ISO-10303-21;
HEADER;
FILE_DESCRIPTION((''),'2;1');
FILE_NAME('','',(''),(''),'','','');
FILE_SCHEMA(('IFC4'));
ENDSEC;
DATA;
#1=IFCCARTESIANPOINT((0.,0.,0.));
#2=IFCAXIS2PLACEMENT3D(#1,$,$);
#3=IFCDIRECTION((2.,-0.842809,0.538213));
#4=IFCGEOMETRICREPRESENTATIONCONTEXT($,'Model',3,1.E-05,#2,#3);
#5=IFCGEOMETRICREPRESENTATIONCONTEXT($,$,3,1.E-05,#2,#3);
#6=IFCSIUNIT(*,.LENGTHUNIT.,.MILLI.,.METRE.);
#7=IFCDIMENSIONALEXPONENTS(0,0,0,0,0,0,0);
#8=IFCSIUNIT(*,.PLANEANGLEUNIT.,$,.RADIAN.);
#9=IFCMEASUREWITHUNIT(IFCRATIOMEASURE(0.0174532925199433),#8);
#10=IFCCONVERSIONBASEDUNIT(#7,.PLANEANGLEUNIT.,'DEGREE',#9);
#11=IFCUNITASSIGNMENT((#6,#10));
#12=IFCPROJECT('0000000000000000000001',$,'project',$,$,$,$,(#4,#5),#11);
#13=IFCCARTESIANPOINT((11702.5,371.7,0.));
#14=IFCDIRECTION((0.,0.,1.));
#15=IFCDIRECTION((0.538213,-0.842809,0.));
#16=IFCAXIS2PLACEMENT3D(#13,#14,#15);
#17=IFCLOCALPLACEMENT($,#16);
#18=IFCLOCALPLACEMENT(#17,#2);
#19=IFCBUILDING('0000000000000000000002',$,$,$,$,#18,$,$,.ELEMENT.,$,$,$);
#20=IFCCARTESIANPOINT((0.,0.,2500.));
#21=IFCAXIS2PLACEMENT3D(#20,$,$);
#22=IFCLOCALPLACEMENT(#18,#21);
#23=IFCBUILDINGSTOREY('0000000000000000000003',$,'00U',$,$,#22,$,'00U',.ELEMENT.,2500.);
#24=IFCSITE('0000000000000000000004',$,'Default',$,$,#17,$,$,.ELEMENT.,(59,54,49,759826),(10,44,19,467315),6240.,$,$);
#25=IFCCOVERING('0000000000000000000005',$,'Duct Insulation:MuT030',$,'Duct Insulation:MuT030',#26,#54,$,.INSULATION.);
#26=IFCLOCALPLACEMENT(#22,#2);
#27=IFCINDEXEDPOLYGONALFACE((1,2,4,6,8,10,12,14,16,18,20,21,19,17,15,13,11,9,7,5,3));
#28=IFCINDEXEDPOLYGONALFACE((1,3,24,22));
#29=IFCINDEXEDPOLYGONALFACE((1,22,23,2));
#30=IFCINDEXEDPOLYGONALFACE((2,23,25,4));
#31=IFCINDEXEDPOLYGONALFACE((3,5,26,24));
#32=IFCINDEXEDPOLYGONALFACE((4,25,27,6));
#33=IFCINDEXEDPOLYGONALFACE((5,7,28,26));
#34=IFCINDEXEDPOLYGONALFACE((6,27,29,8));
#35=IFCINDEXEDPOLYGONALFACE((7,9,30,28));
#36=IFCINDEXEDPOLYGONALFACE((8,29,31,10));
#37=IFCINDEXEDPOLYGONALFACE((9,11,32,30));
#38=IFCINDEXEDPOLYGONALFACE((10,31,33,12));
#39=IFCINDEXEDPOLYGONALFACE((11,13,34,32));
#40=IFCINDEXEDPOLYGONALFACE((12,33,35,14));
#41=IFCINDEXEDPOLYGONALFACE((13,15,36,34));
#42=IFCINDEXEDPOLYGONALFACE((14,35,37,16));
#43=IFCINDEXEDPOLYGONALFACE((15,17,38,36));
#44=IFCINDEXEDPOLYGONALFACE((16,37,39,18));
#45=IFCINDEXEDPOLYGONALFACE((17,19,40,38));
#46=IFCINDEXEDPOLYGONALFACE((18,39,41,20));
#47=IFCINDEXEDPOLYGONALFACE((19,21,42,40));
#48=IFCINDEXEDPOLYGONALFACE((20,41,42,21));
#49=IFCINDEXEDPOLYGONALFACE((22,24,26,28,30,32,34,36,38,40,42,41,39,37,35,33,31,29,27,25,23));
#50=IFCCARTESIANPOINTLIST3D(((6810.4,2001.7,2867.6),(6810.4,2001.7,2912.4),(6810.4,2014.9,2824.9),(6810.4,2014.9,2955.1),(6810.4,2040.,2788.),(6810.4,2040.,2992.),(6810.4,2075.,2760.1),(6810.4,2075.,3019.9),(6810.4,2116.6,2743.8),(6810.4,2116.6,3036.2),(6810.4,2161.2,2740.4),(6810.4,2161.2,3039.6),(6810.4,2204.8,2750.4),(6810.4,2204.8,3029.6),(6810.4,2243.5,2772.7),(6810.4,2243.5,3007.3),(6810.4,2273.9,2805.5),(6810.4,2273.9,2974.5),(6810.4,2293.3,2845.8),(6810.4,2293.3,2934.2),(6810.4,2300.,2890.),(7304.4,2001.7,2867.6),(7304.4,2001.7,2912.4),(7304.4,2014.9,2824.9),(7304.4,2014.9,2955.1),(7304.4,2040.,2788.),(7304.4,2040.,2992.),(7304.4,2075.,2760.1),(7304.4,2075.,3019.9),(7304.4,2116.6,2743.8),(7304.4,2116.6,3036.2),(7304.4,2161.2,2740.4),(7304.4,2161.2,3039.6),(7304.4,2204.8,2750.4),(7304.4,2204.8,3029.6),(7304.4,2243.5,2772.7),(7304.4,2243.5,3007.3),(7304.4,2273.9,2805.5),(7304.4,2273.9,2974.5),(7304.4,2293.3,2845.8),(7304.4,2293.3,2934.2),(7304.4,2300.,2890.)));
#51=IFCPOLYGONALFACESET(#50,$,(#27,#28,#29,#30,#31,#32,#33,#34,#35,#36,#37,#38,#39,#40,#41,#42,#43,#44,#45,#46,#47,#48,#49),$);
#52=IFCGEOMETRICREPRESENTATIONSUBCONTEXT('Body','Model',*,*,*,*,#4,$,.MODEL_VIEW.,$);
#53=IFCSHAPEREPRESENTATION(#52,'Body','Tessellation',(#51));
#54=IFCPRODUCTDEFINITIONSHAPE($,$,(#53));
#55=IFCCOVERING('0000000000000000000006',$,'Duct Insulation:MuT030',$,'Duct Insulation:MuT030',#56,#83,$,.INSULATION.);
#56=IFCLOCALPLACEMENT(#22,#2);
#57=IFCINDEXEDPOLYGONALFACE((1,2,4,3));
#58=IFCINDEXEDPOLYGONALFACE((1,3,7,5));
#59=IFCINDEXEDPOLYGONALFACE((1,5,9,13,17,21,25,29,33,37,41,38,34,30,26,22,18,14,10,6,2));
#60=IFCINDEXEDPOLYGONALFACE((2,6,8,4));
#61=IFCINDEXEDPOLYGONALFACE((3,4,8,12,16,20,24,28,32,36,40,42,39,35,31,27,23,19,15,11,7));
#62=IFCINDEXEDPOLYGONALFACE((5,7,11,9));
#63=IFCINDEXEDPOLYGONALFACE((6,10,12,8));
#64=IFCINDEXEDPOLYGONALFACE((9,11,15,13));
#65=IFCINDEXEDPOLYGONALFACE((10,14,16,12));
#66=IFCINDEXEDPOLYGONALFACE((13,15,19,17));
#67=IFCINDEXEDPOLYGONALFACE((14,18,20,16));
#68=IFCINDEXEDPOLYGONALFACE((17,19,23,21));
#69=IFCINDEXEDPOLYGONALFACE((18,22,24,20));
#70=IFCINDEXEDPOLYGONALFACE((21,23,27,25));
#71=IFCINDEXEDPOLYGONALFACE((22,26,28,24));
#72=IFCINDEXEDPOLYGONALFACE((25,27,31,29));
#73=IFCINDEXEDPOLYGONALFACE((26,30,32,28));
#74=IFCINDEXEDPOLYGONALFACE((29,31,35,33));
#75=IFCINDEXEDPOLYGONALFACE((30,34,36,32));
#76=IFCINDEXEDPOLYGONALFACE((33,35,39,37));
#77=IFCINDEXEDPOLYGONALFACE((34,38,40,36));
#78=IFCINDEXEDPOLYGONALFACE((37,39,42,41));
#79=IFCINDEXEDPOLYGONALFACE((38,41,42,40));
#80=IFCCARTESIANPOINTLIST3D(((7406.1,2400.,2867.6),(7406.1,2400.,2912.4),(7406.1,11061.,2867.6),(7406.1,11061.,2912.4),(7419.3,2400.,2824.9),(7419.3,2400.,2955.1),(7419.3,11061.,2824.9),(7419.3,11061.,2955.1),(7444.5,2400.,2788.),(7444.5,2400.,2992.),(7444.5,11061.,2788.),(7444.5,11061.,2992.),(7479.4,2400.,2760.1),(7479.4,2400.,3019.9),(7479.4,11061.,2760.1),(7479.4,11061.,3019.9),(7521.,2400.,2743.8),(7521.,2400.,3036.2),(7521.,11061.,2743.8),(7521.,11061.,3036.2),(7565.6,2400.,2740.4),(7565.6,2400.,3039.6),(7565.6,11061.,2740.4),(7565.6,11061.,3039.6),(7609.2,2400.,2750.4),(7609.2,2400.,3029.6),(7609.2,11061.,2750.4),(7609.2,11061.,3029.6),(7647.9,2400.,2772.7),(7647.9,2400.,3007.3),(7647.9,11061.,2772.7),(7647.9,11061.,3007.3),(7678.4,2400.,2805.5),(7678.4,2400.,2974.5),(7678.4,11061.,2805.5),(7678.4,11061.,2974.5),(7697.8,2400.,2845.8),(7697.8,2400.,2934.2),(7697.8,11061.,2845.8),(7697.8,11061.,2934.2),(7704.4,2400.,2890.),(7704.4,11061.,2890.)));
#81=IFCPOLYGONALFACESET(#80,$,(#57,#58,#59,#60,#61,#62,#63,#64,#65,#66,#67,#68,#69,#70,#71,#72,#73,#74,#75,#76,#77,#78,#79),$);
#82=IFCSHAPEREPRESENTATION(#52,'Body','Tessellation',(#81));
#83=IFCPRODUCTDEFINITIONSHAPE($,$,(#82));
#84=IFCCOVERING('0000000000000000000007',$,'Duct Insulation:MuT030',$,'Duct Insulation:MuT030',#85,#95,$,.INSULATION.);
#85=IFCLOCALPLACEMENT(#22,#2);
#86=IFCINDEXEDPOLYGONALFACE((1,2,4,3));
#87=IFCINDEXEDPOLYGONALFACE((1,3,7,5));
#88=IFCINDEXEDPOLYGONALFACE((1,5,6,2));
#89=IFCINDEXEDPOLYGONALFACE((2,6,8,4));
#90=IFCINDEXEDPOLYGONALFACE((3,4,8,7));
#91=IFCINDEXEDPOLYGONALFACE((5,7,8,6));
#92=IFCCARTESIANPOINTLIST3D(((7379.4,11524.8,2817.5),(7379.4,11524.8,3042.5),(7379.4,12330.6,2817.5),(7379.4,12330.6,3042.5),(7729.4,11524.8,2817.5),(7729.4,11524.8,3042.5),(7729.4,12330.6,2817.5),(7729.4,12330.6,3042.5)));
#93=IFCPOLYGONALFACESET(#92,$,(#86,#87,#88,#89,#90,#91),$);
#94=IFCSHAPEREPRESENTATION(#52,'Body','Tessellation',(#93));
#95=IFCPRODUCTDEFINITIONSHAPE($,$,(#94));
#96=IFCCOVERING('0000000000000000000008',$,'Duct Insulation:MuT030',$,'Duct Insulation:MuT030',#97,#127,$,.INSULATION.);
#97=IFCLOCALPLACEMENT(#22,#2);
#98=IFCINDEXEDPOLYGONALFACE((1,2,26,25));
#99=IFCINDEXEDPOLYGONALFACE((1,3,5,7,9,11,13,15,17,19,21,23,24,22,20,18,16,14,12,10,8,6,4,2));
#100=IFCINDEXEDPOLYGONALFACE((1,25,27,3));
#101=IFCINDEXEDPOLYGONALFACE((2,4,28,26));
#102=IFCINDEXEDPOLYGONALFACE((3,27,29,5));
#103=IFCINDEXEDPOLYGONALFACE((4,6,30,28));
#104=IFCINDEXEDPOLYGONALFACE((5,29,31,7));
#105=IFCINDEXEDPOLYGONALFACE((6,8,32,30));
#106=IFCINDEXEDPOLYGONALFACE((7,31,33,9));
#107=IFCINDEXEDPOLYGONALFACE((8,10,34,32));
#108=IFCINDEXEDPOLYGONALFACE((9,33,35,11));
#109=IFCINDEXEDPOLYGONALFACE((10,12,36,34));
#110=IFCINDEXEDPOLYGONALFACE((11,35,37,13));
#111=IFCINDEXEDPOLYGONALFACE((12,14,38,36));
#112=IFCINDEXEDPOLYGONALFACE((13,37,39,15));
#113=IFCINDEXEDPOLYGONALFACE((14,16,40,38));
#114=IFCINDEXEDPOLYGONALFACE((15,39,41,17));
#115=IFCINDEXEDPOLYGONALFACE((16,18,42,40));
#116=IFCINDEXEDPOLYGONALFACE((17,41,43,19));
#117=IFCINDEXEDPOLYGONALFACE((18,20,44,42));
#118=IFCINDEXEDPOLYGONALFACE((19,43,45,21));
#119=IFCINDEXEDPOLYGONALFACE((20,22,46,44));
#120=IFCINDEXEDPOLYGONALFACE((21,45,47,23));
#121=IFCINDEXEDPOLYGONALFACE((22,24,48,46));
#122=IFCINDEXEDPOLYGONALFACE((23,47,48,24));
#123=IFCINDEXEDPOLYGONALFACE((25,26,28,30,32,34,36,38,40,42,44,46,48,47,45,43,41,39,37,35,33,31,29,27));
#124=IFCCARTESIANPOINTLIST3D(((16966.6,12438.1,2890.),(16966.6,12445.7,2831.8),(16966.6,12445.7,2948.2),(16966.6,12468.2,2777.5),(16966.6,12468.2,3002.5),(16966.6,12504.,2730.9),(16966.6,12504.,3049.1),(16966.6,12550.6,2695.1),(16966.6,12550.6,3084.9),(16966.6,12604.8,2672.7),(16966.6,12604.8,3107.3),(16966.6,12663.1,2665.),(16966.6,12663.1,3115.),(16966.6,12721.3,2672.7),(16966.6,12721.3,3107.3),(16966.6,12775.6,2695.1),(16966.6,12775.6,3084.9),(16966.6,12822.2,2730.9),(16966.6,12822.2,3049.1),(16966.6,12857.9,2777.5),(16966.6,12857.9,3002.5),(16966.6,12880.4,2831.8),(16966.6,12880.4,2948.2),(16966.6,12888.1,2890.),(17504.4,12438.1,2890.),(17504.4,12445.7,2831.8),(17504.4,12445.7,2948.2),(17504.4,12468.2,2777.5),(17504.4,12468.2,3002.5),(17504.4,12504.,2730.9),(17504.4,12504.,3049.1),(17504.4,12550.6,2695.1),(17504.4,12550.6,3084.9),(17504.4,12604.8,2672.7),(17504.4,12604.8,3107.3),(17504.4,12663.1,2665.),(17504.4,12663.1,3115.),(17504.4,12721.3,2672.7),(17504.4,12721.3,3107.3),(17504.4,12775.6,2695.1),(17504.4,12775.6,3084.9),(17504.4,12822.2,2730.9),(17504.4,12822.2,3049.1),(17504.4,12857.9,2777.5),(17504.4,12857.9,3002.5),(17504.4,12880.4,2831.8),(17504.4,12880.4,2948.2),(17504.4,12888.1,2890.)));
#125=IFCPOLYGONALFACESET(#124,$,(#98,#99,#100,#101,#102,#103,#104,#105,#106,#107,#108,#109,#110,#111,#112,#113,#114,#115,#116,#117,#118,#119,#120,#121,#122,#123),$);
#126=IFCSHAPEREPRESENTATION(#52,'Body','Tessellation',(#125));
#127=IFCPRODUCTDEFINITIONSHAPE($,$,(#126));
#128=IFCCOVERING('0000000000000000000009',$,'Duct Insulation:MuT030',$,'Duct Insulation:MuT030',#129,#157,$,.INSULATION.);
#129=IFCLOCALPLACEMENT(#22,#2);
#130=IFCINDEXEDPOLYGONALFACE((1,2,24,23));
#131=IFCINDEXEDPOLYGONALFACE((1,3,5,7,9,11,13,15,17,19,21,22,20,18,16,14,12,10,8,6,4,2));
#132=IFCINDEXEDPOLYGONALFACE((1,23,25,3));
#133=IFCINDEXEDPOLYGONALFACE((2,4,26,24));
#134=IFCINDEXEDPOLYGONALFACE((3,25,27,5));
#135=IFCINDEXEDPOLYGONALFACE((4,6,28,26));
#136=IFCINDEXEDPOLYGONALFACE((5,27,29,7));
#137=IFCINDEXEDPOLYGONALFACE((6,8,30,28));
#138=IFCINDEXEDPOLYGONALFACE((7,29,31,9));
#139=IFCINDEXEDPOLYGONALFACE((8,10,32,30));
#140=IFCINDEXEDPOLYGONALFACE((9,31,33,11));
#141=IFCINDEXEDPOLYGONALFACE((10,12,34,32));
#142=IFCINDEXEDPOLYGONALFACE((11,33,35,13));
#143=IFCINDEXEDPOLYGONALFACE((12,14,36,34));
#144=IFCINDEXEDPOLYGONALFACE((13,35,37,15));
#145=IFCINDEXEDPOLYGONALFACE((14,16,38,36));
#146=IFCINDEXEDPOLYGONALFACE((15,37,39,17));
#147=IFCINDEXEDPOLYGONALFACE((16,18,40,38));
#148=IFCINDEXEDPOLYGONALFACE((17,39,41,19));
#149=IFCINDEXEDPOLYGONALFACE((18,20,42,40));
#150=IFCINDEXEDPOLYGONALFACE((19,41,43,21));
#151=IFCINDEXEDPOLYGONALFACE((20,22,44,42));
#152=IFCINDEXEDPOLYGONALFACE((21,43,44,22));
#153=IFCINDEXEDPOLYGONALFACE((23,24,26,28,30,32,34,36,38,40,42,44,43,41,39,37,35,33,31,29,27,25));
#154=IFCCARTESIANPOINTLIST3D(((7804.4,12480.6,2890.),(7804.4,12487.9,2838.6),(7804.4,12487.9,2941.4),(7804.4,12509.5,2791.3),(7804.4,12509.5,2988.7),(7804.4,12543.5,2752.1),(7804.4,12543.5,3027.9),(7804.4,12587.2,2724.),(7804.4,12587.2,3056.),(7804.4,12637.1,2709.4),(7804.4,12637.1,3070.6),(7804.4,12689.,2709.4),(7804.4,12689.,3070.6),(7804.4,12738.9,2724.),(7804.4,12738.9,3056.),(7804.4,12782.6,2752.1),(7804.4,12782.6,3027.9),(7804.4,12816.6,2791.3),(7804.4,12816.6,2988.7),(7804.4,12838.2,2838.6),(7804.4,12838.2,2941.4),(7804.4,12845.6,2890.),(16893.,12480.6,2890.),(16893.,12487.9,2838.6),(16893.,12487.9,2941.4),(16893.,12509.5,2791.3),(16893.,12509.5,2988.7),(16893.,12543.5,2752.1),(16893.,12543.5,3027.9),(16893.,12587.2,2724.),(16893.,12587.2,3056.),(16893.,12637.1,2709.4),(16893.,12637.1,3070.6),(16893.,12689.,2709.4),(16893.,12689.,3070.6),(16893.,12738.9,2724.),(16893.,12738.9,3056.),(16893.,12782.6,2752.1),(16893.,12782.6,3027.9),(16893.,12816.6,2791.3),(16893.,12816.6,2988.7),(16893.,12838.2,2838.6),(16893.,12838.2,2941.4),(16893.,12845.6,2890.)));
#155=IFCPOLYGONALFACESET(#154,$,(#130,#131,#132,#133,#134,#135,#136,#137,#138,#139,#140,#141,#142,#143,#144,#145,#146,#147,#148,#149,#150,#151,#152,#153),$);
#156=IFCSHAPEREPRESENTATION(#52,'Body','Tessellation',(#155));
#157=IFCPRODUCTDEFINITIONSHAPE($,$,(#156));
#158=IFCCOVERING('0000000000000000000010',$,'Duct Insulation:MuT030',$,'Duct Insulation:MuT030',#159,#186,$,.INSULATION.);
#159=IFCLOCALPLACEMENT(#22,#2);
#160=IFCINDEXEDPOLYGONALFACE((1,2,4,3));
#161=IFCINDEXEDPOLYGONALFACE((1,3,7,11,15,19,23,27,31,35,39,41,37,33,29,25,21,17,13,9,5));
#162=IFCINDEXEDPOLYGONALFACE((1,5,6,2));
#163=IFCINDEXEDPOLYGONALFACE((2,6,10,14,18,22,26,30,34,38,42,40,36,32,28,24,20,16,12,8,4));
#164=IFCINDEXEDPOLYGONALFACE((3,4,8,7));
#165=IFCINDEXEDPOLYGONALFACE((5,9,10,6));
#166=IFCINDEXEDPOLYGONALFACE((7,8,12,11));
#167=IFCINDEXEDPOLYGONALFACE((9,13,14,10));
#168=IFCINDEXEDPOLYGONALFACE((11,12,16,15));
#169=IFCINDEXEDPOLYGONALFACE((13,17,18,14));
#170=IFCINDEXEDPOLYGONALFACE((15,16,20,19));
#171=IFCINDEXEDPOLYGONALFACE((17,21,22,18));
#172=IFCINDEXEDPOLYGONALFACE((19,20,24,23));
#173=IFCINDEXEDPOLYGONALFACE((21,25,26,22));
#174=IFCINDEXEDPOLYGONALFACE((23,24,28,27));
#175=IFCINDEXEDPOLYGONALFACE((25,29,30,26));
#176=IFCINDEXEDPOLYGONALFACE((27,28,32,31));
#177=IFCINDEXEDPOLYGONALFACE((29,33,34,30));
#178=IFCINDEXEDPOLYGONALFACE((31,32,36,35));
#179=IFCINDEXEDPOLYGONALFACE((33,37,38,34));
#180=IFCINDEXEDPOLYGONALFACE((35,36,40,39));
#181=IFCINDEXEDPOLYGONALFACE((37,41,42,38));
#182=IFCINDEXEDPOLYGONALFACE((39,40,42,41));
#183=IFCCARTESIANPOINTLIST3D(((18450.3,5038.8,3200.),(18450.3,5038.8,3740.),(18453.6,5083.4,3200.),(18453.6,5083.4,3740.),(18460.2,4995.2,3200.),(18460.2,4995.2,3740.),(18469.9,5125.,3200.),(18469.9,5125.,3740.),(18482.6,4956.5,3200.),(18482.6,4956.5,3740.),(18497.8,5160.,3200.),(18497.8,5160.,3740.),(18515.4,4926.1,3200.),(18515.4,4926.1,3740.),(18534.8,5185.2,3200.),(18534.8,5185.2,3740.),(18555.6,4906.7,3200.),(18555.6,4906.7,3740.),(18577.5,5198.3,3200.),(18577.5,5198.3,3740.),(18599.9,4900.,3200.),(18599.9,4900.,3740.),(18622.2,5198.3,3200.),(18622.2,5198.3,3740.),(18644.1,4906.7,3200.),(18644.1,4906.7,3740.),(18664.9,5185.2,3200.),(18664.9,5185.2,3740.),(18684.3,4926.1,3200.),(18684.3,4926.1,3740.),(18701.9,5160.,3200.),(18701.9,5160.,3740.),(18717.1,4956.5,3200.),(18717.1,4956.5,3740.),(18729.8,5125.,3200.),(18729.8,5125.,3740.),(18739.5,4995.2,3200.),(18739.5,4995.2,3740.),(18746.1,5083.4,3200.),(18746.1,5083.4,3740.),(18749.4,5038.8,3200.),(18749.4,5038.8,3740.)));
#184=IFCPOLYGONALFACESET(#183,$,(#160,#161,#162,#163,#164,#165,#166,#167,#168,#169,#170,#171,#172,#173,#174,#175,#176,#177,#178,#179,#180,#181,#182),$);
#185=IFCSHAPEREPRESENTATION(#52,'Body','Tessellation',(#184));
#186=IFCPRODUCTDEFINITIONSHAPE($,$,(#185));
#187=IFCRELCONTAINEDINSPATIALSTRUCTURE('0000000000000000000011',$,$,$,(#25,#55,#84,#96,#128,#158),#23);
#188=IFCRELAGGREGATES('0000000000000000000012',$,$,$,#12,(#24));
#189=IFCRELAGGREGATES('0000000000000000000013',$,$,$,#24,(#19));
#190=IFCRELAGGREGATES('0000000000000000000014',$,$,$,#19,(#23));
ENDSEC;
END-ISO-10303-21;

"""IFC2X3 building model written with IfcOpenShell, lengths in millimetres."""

from ifc_helpers import new_model, entity, si_unit, converted_unit, direction, frame, frame_2d, origin, origin_2d_with_axis, place, context, subcontext, project, spatial, rectangle, circle, extrude, element, save


model = new_model("IFC2X3")

# Units and contexts
model_context = context("Model", 3, precision=1e-05, world=origin(), true_north=direction((2.0, -0.842809, 0.538213)))
context_of_model = context(None, 3, precision=1e-05, world=origin(), true_north=direction((2.0, -0.842809, 0.538213)))
body_context = subcontext(model_context, "Body", "Model", "MODEL_VIEW")
ifc_project = project(units=[si_unit("LENGTHUNIT", "METRE", prefix="MILLI"), converted_unit("PLANEANGLEUNIT", "DEGREE", entity("IfcRatioMeasure", 0.0174532925199433), si_unit("PLANEANGLEUNIT", "RADIAN"), dimensions=[0, 0, 0, 0, 0, 0, 0])], contexts=[model_context, context_of_model])

# Site, building, storey
site_placement = place(None, frame((11702.5, 371.7, 0.0), z_axis=(0.0, 0.0, 1.0), x_axis=(0.538213, -0.842809, 0.0)))
site = spatial("IfcSite", under=ifc_project, at=site_placement, Name="Default", CompositionType="ELEMENT", RefLatitude=(59, 54, 49, 759826), RefLongitude=(10, 44, 19, 467315), RefElevation=6240.0)
building_placement = place(site_placement, origin())
building = spatial("IfcBuilding", under=site, at=building_placement, CompositionType="ELEMENT")
storey_placement = place(building_placement, frame((0.0, 0.0, 2500.0)))
storey = spatial("IfcBuildingStorey", under=building, at=storey_placement, Name="00U", LongName="00U", CompositionType="ELEMENT", Elevation=2500.0)

# Coverings
covering_1_placement = place(storey_placement, origin())
element("IfcCovering", 1, at=covering_1_placement, inside=storey, Name="Duct Insulation:MuT030", ObjectType="Duct Insulation:MuT030", PredefinedType="INSULATION", context=body_context, shape_type="SweptSolid", body=[
    extrude(circle(Radius=150.0, at=frame_2d((0.0, 0.0), x_axis=(1.0, 0.0))), frame((6810.4, 2150.0, 2890.0), z_axis=(1.0, 0.0, 0.0), x_axis=(0.0, 1.0, 0.0)), (0.0, 0.0, 1.0), 494.0),
])
covering_2_placement = place(storey_placement, origin())
element("IfcCovering", 2, at=covering_2_placement, inside=storey, Name="Duct Insulation:MuT030", ObjectType="Duct Insulation:MuT030", PredefinedType="INSULATION", context=body_context, shape_type="SweptSolid", body=[
    extrude(circle(Radius=150.0, at=frame_2d((0.0, 0.0), x_axis=(1.0, 0.0))), frame((7554.4, 2400.0, 2890.0), z_axis=(0.0, 1.0, 0.0), x_axis=(1.0, 0.0, 0.0)), (0.0, 0.0, 1.0), 8661.0),
])
covering_3_placement = place(storey_placement, origin())
element("IfcCovering", 3, at=covering_3_placement, inside=storey, Name="Duct Insulation:MuT030", ObjectType="Duct Insulation:MuT030", PredefinedType="INSULATION", context=body_context, shape_type="SweptSolid", body=[
    extrude(rectangle(XDim=805.8, YDim=350.0, at=frame_2d((0.0, 0.0), x_axis=(1.0, 0.0))), frame((7554.4, 11927.7, 2817.5), z_axis=(0.0, 0.0, 1.0), x_axis=(0.0, -1.0, 0.0)), (0.0, 0.0, 1.0), 225.0),
])
covering_4_placement = place(storey_placement, origin())
element("IfcCovering", 4, at=covering_4_placement, inside=storey, Name="Duct Insulation:MuT030", ObjectType="Duct Insulation:MuT030", PredefinedType="INSULATION", context=body_context, shape_type="SweptSolid", body=[
    extrude(circle(Radius=225.0, at=origin_2d_with_axis()), frame((16966.6, 12663.1, 2890.0), z_axis=(1.0, 0.0, 0.0), x_axis=(0.0, 1.0, 0.0)), (0.0, 0.0, 1.0), 537.8),
])
covering_5_placement = place(storey_placement, origin())
element("IfcCovering", 5, at=covering_5_placement, inside=storey, Name="Duct Insulation:MuT030", ObjectType="Duct Insulation:MuT030", PredefinedType="INSULATION", context=body_context, shape_type="SweptSolid", body=[
    extrude(circle(Radius=182.5, at=origin_2d_with_axis()), frame((7804.4, 12663.1, 2890.0), z_axis=(1.0, 0.0, 0.0), x_axis=(0.0, 1.0, 0.0)), (0.0, 0.0, 1.0), 9088.6),
])
covering_6_placement = place(storey_placement, origin())
element("IfcCovering", 6, at=covering_6_placement, inside=storey, Name="Duct Insulation:MuT030", ObjectType="Duct Insulation:MuT030", PredefinedType="INSULATION", context=body_context, shape_type="SweptSolid", body=[
    extrude(circle(Radius=150.0, at=frame_2d((0.0, 0.0), x_axis=(1.0, 0.0))), frame((18599.9, 5050.0, 3200.0), z_axis=(0.0, 0.0, 1.0), x_axis=(0.0, -1.0, 0.0)), (0.0, 0.0, 1.0), 540.0),
])

save(model, "model.ifc")
